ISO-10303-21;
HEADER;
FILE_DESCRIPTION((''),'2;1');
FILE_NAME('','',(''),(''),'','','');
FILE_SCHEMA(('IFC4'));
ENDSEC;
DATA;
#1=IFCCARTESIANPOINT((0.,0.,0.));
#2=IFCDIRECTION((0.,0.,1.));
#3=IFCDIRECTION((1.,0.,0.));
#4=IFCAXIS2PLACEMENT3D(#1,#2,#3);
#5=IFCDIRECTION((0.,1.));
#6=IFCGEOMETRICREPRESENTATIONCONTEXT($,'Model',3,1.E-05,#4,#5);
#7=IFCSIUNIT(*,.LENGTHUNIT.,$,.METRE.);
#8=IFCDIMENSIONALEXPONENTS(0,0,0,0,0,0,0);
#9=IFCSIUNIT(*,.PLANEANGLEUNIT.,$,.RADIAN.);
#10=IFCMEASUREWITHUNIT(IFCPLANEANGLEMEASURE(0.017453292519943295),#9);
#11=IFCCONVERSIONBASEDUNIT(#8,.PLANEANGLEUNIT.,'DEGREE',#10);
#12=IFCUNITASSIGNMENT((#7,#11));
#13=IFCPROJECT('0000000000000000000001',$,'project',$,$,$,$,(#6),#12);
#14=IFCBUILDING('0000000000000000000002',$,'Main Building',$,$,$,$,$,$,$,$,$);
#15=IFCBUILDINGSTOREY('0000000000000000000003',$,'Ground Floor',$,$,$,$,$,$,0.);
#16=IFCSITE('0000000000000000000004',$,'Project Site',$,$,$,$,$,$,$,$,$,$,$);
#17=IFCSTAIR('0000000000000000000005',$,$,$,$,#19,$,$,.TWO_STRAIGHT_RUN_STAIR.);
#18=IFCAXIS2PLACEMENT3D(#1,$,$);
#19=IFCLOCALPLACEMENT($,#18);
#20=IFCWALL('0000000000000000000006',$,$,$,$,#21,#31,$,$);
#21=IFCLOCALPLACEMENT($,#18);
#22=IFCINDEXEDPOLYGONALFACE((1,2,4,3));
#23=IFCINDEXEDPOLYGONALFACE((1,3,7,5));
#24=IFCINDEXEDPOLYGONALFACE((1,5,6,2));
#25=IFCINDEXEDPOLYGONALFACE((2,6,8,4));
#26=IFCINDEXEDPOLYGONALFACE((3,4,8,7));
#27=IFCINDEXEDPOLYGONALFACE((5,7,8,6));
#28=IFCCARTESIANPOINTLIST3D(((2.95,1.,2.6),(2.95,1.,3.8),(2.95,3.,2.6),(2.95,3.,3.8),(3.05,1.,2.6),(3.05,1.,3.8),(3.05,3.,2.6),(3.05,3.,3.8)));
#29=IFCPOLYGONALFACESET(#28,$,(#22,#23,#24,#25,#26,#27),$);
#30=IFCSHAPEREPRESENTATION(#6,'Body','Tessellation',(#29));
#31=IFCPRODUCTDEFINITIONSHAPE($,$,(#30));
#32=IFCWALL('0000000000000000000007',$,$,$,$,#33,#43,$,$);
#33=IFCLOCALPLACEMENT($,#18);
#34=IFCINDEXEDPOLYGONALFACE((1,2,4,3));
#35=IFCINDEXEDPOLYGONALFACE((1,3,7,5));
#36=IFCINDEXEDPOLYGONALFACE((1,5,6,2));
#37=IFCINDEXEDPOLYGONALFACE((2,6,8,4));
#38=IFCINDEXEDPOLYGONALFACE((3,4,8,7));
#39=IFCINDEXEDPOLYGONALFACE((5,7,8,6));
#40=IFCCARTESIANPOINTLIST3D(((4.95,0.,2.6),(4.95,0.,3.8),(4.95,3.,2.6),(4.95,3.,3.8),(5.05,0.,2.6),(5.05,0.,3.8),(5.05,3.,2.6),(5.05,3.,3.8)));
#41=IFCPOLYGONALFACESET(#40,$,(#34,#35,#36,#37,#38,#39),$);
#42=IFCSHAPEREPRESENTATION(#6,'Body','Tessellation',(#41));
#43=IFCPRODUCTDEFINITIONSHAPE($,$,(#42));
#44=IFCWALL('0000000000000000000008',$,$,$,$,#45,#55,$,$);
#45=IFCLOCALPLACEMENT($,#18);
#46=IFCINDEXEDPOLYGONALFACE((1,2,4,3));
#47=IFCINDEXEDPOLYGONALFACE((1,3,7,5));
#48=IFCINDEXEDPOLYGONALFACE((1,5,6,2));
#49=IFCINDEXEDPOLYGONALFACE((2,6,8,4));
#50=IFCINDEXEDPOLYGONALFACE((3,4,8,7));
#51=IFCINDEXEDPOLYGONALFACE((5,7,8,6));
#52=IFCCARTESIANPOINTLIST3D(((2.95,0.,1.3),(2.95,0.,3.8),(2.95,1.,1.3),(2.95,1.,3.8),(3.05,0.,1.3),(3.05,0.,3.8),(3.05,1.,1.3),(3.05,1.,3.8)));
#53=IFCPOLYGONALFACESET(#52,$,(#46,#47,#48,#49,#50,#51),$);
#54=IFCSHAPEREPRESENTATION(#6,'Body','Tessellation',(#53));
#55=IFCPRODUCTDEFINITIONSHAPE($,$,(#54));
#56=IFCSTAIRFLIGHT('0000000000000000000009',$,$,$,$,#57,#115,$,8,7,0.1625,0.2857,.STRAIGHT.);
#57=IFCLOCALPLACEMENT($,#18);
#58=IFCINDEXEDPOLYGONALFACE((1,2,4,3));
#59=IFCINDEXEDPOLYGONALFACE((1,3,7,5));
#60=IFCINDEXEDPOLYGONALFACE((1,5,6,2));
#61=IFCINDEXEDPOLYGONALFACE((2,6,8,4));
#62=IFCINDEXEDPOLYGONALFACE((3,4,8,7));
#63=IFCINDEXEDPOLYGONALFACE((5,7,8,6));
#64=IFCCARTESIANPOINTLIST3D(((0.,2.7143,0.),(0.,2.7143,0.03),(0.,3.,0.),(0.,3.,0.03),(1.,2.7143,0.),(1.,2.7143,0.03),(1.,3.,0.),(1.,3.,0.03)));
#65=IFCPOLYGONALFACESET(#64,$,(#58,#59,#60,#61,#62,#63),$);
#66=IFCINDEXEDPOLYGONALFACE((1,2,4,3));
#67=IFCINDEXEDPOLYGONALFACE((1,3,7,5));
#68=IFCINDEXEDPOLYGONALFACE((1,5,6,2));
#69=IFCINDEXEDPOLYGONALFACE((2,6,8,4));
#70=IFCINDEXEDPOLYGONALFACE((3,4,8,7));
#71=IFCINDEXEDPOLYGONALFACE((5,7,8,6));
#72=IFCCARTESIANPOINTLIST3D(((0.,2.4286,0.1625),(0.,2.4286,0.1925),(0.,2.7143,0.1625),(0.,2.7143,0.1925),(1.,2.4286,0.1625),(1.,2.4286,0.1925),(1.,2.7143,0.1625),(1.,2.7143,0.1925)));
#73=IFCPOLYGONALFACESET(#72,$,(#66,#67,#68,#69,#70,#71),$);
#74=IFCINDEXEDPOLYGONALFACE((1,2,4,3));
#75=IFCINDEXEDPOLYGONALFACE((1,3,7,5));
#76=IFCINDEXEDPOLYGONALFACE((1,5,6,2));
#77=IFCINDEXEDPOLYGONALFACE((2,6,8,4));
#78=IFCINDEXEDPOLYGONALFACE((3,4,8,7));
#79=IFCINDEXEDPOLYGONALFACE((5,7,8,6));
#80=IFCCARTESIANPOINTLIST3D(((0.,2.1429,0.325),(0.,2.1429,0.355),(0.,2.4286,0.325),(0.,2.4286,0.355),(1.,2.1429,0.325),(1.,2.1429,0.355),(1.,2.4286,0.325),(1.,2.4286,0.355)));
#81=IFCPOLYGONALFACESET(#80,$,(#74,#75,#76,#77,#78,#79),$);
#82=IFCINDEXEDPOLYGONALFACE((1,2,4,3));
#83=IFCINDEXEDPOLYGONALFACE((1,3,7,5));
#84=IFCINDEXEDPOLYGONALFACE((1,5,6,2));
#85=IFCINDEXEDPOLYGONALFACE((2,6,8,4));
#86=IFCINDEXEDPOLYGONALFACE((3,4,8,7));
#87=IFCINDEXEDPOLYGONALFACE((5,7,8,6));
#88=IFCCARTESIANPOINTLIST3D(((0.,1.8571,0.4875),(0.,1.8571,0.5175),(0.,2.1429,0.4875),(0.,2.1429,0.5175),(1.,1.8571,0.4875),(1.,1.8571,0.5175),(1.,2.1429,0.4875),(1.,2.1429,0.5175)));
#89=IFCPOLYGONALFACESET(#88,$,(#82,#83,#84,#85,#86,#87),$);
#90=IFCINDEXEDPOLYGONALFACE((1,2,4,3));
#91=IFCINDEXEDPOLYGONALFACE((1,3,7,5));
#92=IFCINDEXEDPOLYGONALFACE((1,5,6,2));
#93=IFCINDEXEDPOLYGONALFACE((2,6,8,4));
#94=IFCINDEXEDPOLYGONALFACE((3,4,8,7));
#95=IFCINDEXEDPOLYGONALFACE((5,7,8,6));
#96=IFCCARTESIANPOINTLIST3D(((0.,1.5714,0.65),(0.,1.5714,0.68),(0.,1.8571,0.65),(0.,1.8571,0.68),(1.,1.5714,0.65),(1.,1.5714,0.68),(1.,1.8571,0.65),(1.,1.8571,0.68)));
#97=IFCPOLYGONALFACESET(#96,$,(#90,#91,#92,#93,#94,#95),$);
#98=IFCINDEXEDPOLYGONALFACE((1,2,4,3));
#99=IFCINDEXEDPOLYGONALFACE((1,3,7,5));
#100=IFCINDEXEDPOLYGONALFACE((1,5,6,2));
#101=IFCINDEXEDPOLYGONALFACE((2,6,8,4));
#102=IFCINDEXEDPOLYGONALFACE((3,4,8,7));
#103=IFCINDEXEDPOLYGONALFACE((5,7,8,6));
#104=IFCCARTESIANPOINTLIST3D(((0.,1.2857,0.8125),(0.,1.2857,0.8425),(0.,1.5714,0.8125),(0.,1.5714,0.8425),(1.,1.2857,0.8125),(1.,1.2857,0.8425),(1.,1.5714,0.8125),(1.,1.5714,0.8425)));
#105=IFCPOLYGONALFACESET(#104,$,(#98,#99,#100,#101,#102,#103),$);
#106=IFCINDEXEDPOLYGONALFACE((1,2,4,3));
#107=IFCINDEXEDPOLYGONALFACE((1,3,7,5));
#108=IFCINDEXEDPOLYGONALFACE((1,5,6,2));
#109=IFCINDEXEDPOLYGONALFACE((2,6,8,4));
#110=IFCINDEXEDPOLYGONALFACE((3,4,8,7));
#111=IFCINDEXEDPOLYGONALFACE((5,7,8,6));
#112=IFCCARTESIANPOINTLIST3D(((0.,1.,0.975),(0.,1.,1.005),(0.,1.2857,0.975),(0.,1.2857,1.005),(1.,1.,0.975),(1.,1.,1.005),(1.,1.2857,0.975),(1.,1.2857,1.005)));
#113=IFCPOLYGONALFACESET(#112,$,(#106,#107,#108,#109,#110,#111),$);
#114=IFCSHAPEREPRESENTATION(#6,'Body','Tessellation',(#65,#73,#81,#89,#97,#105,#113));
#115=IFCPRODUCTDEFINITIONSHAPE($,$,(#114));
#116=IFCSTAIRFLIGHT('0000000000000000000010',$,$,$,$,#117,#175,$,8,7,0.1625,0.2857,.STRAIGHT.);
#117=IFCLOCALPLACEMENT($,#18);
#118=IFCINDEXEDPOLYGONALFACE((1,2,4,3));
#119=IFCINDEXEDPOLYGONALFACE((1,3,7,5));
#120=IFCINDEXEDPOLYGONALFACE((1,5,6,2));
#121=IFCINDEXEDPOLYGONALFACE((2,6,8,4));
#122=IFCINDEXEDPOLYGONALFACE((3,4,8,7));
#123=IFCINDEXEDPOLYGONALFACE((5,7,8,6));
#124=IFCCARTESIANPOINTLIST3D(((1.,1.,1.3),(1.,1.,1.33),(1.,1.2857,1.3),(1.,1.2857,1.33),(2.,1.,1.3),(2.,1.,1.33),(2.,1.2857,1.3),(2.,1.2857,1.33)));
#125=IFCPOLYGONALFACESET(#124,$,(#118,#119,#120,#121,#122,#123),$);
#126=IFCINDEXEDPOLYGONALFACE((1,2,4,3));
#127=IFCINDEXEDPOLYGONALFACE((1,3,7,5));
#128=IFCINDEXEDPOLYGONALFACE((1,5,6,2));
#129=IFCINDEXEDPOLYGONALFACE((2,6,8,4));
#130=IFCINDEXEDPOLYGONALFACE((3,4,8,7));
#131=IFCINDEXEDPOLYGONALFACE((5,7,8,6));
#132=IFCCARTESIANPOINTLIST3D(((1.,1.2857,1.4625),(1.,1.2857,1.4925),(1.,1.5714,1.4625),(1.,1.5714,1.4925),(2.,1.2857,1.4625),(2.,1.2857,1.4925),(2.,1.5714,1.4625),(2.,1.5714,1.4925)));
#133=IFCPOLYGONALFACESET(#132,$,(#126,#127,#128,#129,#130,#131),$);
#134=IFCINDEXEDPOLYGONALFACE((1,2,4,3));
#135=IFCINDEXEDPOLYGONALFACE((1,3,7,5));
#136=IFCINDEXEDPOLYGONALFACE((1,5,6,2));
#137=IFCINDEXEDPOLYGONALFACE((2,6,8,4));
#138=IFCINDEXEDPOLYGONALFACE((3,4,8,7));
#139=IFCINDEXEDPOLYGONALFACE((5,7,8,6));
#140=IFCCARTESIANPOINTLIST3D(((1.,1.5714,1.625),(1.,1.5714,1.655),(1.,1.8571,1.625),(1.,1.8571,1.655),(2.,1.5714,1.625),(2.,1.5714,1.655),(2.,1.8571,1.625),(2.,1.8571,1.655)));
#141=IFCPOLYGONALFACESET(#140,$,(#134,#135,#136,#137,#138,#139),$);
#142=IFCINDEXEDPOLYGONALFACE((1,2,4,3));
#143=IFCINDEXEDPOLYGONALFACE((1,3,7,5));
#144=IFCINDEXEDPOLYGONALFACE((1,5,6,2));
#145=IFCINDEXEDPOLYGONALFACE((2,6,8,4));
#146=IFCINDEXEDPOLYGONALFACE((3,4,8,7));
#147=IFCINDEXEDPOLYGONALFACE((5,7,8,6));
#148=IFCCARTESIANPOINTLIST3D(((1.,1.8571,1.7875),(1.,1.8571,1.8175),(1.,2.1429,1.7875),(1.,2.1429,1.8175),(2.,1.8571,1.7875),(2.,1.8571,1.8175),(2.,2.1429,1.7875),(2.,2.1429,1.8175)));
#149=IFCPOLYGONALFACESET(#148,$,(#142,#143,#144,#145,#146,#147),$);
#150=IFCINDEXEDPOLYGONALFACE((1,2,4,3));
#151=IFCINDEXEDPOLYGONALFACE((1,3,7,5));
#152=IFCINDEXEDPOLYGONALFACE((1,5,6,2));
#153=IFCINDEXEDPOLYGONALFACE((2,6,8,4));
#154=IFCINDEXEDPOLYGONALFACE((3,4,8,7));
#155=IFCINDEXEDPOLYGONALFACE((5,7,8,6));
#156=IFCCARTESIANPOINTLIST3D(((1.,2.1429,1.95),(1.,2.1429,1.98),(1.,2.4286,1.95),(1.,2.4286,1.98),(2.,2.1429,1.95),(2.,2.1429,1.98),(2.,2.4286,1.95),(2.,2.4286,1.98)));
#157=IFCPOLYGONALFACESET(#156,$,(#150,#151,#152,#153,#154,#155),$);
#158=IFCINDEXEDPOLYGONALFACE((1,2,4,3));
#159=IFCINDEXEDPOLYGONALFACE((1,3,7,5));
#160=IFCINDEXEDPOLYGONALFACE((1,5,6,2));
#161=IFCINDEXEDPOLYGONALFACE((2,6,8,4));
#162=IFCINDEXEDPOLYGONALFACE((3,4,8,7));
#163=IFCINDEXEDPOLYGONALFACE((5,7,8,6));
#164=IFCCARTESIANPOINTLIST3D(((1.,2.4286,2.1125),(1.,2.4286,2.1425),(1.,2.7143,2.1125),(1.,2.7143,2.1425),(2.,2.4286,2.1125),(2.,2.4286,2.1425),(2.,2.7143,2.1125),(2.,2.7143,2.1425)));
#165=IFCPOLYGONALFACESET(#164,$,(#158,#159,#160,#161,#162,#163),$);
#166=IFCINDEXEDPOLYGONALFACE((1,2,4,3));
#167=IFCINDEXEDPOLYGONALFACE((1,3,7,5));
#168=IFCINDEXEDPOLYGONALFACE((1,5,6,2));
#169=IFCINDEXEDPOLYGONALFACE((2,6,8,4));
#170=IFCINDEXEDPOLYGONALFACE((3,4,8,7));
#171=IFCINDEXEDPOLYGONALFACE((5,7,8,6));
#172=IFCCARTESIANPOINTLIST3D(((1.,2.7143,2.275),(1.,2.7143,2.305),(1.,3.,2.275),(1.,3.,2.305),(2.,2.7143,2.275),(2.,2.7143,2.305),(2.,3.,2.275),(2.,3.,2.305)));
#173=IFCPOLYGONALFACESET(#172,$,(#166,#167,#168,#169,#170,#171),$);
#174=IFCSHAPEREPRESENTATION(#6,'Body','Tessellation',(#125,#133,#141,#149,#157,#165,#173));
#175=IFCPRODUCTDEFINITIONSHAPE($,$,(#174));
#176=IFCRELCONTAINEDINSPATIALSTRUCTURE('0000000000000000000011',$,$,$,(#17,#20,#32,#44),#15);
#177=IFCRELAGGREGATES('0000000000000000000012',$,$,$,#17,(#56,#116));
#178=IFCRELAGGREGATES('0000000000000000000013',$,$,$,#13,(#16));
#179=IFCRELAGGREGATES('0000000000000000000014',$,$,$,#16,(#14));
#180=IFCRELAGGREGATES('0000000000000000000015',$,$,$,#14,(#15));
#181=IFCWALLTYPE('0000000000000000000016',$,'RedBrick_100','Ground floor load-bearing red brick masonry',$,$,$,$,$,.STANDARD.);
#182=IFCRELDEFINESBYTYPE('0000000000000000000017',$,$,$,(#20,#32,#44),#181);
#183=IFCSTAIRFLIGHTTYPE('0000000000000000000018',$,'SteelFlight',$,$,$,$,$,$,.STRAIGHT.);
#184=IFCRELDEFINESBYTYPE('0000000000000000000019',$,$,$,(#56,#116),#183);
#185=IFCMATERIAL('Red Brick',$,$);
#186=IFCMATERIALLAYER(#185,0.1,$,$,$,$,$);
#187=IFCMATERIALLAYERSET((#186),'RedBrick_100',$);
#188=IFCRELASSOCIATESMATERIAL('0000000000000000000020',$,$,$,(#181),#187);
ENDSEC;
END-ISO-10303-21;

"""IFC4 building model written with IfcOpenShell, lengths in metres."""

from ifc_helpers import new_model, entity, si_unit, converted_unit, direction, frame, frame_2d, origin, origin_with_axes, place, context, project, spatial, rectangle, extrude, material, layer, layer_set, type_object, element, aggregate, save


model = new_model("IFC4")

# Units and contexts
model_context = context("Model", 3, precision=1e-05, world=origin_with_axes(), true_north=direction((0.0, 1.0)))
ifc_project = project(units=[si_unit("LENGTHUNIT", "METRE"), converted_unit("PLANEANGLEUNIT", "DEGREE", entity("IfcPlaneAngleMeasure", 0.017453292519943295), si_unit("PLANEANGLEUNIT", "RADIAN"), dimensions=[0, 0, 0, 0, 0, 0, 0])], contexts=[model_context])

# Site, building, storey
site = spatial("IfcSite", under=ifc_project, Name="Project Site")
building = spatial("IfcBuilding", under=site, Name="Main Building")
storey = spatial("IfcBuildingStorey", under=building, Name="Ground Floor", Elevation=0.0)

# Stair
stair_placement = place(None, origin_with_axes())
stair = element("IfcStair", 1, at=stair_placement, inside=storey, PredefinedType="TWO_STRAIGHT_RUN_STAIR")

# Walls
ifc_material_1 = material(Name="Red Brick")
ifc_layer_1 = layer(ifc_material_1, 0.1)
ifc_layer_set_1 = layer_set([ifc_layer_1], Name="RedBrick_100")
wall_type = type_object("IfcWallType", Name="RedBrick_100", Description="Ground floor load-bearing red brick masonry", PredefinedType="STANDARD", material=ifc_layer_set_1)
for number, where, z_axis, x_axis in (
    (2, (3.0, 1.0, 2.6), (0.0, 0.0, 1.0), (0.0, 1.0, 0.0)),
):
    element("IfcWall", number, at=place(None, frame(where, z_axis=z_axis, x_axis=x_axis)), inside=storey, type_object=wall_type, context=model_context, shape_type="SweptSolid", body=[
        extrude(rectangle(XDim=2.0, YDim=0.1, at=frame_2d((1.0, 0.0))), origin(), (0.0, 0.0, 1.0), 1.2),
    ])
wall_1_placement = place(None, frame((5.0, 0.0, 2.6), z_axis=(0.0, 0.0, 1.0), x_axis=(0.0, 1.0, 0.0)))
element("IfcWall", 3, at=wall_1_placement, inside=storey, type_object=wall_type, context=model_context, shape_type="SweptSolid", body=[
    extrude(rectangle(XDim=3.0, YDim=0.1, at=frame_2d((1.5, 0.0))), origin(), (0.0, 0.0, 1.0), 1.2),
])
wall_2_placement = place(None, frame((3.0, 0.0, 1.3), z_axis=(0.0, 0.0, 1.0), x_axis=(0.0, 1.0, 0.0)))
element("IfcWall", 4, at=wall_2_placement, inside=storey, type_object=wall_type, context=model_context, shape_type="SweptSolid", body=[
    extrude(rectangle(XDim=1.0, YDim=0.1, at=frame_2d((0.5, 0.0))), origin(), (0.0, 0.0, 1.0), 2.5),
])

# Stair flights
stair_flight_type = type_object("IfcStairFlightType", Name="SteelFlight", PredefinedType="STRAIGHT")
stair_flight_1_placement = place(stair_placement, frame((0.5, 3.0, 0.0), z_axis=(0.0, 0.0, 1.0), x_axis=(0.0, -1.0, 0.0)))
stair_flight_1 = element("IfcStairFlight", 5, at=stair_flight_1_placement, type_object=stair_flight_type, NumberOfRisers=8, NumberOfTreads=7, PredefinedType="STRAIGHT", RiserHeight=0.1625, TreadLength=0.2857, context=model_context, shape_type="SweptSolid", body=[
    extrude(rectangle(XDim=0.2857, YDim=1.0, at=frame_2d((0.1429, 0.0))), origin(), (0.0, 0.0, 1.0), 0.03),
    extrude(rectangle(XDim=0.2857, YDim=1.0, at=frame_2d((0.1429, 0.0))), frame((0.2857, 0.0, 0.1625)), (0.0, 0.0, 1.0), 0.03),
    extrude(rectangle(XDim=0.2857, YDim=1.0, at=frame_2d((0.1429, 0.0))), frame((0.5714, 0.0, 0.325)), (0.0, 0.0, 1.0), 0.03),
    extrude(rectangle(XDim=0.2857, YDim=1.0, at=frame_2d((0.1429, 0.0))), frame((0.8571, 0.0, 0.4875)), (0.0, 0.0, 1.0), 0.03),
    extrude(rectangle(XDim=0.2857, YDim=1.0, at=frame_2d((0.1429, 0.0))), frame((1.1429, 0.0, 0.65)), (0.0, 0.0, 1.0), 0.03),
    extrude(rectangle(XDim=0.2857, YDim=1.0, at=frame_2d((0.1429, 0.0))), frame((1.4286, 0.0, 0.8125)), (0.0, 0.0, 1.0), 0.03),
    extrude(rectangle(XDim=0.2857, YDim=1.0, at=frame_2d((0.1429, 0.0))), frame((1.7143, 0.0, 0.975)), (0.0, 0.0, 1.0), 0.03),
])
stair_flight_2_placement = place(stair_placement, frame((1.5, 1.0, 1.3), z_axis=(0.0, 0.0, 1.0), x_axis=(0.0, 1.0, 0.0)))
stair_flight_2 = element("IfcStairFlight", 6, at=stair_flight_2_placement, type_object=stair_flight_type, NumberOfRisers=8, NumberOfTreads=7, PredefinedType="STRAIGHT", RiserHeight=0.1625, TreadLength=0.2857, context=model_context, shape_type="SweptSolid", body=[
    extrude(rectangle(XDim=0.2857, YDim=1.0, at=frame_2d((0.1429, 0.0))), origin(), (0.0, 0.0, 1.0), 0.03),
    extrude(rectangle(XDim=0.2857, YDim=1.0, at=frame_2d((0.1429, 0.0))), frame((0.2857, 0.0, 0.1625)), (0.0, 0.0, 1.0), 0.03),
    extrude(rectangle(XDim=0.2857, YDim=1.0, at=frame_2d((0.1429, 0.0))), frame((0.5714, 0.0, 0.325)), (0.0, 0.0, 1.0), 0.03),
    extrude(rectangle(XDim=0.2857, YDim=1.0, at=frame_2d((0.1429, 0.0))), frame((0.8571, 0.0, 0.4875)), (0.0, 0.0, 1.0), 0.03),
    extrude(rectangle(XDim=0.2857, YDim=1.0, at=frame_2d((0.1429, 0.0))), frame((1.1429, 0.0, 0.65)), (0.0, 0.0, 1.0), 0.03),
    extrude(rectangle(XDim=0.2857, YDim=1.0, at=frame_2d((0.1429, 0.0))), frame((1.4286, 0.0, 0.8125)), (0.0, 0.0, 1.0), 0.03),
    extrude(rectangle(XDim=0.2857, YDim=1.0, at=frame_2d((0.1429, 0.0))), frame((1.7143, 0.0, 0.975)), (0.0, 0.0, 1.0), 0.03),
])
aggregate(stair, [stair_flight_1, stair_flight_2])

save(model, "model.ifc")
